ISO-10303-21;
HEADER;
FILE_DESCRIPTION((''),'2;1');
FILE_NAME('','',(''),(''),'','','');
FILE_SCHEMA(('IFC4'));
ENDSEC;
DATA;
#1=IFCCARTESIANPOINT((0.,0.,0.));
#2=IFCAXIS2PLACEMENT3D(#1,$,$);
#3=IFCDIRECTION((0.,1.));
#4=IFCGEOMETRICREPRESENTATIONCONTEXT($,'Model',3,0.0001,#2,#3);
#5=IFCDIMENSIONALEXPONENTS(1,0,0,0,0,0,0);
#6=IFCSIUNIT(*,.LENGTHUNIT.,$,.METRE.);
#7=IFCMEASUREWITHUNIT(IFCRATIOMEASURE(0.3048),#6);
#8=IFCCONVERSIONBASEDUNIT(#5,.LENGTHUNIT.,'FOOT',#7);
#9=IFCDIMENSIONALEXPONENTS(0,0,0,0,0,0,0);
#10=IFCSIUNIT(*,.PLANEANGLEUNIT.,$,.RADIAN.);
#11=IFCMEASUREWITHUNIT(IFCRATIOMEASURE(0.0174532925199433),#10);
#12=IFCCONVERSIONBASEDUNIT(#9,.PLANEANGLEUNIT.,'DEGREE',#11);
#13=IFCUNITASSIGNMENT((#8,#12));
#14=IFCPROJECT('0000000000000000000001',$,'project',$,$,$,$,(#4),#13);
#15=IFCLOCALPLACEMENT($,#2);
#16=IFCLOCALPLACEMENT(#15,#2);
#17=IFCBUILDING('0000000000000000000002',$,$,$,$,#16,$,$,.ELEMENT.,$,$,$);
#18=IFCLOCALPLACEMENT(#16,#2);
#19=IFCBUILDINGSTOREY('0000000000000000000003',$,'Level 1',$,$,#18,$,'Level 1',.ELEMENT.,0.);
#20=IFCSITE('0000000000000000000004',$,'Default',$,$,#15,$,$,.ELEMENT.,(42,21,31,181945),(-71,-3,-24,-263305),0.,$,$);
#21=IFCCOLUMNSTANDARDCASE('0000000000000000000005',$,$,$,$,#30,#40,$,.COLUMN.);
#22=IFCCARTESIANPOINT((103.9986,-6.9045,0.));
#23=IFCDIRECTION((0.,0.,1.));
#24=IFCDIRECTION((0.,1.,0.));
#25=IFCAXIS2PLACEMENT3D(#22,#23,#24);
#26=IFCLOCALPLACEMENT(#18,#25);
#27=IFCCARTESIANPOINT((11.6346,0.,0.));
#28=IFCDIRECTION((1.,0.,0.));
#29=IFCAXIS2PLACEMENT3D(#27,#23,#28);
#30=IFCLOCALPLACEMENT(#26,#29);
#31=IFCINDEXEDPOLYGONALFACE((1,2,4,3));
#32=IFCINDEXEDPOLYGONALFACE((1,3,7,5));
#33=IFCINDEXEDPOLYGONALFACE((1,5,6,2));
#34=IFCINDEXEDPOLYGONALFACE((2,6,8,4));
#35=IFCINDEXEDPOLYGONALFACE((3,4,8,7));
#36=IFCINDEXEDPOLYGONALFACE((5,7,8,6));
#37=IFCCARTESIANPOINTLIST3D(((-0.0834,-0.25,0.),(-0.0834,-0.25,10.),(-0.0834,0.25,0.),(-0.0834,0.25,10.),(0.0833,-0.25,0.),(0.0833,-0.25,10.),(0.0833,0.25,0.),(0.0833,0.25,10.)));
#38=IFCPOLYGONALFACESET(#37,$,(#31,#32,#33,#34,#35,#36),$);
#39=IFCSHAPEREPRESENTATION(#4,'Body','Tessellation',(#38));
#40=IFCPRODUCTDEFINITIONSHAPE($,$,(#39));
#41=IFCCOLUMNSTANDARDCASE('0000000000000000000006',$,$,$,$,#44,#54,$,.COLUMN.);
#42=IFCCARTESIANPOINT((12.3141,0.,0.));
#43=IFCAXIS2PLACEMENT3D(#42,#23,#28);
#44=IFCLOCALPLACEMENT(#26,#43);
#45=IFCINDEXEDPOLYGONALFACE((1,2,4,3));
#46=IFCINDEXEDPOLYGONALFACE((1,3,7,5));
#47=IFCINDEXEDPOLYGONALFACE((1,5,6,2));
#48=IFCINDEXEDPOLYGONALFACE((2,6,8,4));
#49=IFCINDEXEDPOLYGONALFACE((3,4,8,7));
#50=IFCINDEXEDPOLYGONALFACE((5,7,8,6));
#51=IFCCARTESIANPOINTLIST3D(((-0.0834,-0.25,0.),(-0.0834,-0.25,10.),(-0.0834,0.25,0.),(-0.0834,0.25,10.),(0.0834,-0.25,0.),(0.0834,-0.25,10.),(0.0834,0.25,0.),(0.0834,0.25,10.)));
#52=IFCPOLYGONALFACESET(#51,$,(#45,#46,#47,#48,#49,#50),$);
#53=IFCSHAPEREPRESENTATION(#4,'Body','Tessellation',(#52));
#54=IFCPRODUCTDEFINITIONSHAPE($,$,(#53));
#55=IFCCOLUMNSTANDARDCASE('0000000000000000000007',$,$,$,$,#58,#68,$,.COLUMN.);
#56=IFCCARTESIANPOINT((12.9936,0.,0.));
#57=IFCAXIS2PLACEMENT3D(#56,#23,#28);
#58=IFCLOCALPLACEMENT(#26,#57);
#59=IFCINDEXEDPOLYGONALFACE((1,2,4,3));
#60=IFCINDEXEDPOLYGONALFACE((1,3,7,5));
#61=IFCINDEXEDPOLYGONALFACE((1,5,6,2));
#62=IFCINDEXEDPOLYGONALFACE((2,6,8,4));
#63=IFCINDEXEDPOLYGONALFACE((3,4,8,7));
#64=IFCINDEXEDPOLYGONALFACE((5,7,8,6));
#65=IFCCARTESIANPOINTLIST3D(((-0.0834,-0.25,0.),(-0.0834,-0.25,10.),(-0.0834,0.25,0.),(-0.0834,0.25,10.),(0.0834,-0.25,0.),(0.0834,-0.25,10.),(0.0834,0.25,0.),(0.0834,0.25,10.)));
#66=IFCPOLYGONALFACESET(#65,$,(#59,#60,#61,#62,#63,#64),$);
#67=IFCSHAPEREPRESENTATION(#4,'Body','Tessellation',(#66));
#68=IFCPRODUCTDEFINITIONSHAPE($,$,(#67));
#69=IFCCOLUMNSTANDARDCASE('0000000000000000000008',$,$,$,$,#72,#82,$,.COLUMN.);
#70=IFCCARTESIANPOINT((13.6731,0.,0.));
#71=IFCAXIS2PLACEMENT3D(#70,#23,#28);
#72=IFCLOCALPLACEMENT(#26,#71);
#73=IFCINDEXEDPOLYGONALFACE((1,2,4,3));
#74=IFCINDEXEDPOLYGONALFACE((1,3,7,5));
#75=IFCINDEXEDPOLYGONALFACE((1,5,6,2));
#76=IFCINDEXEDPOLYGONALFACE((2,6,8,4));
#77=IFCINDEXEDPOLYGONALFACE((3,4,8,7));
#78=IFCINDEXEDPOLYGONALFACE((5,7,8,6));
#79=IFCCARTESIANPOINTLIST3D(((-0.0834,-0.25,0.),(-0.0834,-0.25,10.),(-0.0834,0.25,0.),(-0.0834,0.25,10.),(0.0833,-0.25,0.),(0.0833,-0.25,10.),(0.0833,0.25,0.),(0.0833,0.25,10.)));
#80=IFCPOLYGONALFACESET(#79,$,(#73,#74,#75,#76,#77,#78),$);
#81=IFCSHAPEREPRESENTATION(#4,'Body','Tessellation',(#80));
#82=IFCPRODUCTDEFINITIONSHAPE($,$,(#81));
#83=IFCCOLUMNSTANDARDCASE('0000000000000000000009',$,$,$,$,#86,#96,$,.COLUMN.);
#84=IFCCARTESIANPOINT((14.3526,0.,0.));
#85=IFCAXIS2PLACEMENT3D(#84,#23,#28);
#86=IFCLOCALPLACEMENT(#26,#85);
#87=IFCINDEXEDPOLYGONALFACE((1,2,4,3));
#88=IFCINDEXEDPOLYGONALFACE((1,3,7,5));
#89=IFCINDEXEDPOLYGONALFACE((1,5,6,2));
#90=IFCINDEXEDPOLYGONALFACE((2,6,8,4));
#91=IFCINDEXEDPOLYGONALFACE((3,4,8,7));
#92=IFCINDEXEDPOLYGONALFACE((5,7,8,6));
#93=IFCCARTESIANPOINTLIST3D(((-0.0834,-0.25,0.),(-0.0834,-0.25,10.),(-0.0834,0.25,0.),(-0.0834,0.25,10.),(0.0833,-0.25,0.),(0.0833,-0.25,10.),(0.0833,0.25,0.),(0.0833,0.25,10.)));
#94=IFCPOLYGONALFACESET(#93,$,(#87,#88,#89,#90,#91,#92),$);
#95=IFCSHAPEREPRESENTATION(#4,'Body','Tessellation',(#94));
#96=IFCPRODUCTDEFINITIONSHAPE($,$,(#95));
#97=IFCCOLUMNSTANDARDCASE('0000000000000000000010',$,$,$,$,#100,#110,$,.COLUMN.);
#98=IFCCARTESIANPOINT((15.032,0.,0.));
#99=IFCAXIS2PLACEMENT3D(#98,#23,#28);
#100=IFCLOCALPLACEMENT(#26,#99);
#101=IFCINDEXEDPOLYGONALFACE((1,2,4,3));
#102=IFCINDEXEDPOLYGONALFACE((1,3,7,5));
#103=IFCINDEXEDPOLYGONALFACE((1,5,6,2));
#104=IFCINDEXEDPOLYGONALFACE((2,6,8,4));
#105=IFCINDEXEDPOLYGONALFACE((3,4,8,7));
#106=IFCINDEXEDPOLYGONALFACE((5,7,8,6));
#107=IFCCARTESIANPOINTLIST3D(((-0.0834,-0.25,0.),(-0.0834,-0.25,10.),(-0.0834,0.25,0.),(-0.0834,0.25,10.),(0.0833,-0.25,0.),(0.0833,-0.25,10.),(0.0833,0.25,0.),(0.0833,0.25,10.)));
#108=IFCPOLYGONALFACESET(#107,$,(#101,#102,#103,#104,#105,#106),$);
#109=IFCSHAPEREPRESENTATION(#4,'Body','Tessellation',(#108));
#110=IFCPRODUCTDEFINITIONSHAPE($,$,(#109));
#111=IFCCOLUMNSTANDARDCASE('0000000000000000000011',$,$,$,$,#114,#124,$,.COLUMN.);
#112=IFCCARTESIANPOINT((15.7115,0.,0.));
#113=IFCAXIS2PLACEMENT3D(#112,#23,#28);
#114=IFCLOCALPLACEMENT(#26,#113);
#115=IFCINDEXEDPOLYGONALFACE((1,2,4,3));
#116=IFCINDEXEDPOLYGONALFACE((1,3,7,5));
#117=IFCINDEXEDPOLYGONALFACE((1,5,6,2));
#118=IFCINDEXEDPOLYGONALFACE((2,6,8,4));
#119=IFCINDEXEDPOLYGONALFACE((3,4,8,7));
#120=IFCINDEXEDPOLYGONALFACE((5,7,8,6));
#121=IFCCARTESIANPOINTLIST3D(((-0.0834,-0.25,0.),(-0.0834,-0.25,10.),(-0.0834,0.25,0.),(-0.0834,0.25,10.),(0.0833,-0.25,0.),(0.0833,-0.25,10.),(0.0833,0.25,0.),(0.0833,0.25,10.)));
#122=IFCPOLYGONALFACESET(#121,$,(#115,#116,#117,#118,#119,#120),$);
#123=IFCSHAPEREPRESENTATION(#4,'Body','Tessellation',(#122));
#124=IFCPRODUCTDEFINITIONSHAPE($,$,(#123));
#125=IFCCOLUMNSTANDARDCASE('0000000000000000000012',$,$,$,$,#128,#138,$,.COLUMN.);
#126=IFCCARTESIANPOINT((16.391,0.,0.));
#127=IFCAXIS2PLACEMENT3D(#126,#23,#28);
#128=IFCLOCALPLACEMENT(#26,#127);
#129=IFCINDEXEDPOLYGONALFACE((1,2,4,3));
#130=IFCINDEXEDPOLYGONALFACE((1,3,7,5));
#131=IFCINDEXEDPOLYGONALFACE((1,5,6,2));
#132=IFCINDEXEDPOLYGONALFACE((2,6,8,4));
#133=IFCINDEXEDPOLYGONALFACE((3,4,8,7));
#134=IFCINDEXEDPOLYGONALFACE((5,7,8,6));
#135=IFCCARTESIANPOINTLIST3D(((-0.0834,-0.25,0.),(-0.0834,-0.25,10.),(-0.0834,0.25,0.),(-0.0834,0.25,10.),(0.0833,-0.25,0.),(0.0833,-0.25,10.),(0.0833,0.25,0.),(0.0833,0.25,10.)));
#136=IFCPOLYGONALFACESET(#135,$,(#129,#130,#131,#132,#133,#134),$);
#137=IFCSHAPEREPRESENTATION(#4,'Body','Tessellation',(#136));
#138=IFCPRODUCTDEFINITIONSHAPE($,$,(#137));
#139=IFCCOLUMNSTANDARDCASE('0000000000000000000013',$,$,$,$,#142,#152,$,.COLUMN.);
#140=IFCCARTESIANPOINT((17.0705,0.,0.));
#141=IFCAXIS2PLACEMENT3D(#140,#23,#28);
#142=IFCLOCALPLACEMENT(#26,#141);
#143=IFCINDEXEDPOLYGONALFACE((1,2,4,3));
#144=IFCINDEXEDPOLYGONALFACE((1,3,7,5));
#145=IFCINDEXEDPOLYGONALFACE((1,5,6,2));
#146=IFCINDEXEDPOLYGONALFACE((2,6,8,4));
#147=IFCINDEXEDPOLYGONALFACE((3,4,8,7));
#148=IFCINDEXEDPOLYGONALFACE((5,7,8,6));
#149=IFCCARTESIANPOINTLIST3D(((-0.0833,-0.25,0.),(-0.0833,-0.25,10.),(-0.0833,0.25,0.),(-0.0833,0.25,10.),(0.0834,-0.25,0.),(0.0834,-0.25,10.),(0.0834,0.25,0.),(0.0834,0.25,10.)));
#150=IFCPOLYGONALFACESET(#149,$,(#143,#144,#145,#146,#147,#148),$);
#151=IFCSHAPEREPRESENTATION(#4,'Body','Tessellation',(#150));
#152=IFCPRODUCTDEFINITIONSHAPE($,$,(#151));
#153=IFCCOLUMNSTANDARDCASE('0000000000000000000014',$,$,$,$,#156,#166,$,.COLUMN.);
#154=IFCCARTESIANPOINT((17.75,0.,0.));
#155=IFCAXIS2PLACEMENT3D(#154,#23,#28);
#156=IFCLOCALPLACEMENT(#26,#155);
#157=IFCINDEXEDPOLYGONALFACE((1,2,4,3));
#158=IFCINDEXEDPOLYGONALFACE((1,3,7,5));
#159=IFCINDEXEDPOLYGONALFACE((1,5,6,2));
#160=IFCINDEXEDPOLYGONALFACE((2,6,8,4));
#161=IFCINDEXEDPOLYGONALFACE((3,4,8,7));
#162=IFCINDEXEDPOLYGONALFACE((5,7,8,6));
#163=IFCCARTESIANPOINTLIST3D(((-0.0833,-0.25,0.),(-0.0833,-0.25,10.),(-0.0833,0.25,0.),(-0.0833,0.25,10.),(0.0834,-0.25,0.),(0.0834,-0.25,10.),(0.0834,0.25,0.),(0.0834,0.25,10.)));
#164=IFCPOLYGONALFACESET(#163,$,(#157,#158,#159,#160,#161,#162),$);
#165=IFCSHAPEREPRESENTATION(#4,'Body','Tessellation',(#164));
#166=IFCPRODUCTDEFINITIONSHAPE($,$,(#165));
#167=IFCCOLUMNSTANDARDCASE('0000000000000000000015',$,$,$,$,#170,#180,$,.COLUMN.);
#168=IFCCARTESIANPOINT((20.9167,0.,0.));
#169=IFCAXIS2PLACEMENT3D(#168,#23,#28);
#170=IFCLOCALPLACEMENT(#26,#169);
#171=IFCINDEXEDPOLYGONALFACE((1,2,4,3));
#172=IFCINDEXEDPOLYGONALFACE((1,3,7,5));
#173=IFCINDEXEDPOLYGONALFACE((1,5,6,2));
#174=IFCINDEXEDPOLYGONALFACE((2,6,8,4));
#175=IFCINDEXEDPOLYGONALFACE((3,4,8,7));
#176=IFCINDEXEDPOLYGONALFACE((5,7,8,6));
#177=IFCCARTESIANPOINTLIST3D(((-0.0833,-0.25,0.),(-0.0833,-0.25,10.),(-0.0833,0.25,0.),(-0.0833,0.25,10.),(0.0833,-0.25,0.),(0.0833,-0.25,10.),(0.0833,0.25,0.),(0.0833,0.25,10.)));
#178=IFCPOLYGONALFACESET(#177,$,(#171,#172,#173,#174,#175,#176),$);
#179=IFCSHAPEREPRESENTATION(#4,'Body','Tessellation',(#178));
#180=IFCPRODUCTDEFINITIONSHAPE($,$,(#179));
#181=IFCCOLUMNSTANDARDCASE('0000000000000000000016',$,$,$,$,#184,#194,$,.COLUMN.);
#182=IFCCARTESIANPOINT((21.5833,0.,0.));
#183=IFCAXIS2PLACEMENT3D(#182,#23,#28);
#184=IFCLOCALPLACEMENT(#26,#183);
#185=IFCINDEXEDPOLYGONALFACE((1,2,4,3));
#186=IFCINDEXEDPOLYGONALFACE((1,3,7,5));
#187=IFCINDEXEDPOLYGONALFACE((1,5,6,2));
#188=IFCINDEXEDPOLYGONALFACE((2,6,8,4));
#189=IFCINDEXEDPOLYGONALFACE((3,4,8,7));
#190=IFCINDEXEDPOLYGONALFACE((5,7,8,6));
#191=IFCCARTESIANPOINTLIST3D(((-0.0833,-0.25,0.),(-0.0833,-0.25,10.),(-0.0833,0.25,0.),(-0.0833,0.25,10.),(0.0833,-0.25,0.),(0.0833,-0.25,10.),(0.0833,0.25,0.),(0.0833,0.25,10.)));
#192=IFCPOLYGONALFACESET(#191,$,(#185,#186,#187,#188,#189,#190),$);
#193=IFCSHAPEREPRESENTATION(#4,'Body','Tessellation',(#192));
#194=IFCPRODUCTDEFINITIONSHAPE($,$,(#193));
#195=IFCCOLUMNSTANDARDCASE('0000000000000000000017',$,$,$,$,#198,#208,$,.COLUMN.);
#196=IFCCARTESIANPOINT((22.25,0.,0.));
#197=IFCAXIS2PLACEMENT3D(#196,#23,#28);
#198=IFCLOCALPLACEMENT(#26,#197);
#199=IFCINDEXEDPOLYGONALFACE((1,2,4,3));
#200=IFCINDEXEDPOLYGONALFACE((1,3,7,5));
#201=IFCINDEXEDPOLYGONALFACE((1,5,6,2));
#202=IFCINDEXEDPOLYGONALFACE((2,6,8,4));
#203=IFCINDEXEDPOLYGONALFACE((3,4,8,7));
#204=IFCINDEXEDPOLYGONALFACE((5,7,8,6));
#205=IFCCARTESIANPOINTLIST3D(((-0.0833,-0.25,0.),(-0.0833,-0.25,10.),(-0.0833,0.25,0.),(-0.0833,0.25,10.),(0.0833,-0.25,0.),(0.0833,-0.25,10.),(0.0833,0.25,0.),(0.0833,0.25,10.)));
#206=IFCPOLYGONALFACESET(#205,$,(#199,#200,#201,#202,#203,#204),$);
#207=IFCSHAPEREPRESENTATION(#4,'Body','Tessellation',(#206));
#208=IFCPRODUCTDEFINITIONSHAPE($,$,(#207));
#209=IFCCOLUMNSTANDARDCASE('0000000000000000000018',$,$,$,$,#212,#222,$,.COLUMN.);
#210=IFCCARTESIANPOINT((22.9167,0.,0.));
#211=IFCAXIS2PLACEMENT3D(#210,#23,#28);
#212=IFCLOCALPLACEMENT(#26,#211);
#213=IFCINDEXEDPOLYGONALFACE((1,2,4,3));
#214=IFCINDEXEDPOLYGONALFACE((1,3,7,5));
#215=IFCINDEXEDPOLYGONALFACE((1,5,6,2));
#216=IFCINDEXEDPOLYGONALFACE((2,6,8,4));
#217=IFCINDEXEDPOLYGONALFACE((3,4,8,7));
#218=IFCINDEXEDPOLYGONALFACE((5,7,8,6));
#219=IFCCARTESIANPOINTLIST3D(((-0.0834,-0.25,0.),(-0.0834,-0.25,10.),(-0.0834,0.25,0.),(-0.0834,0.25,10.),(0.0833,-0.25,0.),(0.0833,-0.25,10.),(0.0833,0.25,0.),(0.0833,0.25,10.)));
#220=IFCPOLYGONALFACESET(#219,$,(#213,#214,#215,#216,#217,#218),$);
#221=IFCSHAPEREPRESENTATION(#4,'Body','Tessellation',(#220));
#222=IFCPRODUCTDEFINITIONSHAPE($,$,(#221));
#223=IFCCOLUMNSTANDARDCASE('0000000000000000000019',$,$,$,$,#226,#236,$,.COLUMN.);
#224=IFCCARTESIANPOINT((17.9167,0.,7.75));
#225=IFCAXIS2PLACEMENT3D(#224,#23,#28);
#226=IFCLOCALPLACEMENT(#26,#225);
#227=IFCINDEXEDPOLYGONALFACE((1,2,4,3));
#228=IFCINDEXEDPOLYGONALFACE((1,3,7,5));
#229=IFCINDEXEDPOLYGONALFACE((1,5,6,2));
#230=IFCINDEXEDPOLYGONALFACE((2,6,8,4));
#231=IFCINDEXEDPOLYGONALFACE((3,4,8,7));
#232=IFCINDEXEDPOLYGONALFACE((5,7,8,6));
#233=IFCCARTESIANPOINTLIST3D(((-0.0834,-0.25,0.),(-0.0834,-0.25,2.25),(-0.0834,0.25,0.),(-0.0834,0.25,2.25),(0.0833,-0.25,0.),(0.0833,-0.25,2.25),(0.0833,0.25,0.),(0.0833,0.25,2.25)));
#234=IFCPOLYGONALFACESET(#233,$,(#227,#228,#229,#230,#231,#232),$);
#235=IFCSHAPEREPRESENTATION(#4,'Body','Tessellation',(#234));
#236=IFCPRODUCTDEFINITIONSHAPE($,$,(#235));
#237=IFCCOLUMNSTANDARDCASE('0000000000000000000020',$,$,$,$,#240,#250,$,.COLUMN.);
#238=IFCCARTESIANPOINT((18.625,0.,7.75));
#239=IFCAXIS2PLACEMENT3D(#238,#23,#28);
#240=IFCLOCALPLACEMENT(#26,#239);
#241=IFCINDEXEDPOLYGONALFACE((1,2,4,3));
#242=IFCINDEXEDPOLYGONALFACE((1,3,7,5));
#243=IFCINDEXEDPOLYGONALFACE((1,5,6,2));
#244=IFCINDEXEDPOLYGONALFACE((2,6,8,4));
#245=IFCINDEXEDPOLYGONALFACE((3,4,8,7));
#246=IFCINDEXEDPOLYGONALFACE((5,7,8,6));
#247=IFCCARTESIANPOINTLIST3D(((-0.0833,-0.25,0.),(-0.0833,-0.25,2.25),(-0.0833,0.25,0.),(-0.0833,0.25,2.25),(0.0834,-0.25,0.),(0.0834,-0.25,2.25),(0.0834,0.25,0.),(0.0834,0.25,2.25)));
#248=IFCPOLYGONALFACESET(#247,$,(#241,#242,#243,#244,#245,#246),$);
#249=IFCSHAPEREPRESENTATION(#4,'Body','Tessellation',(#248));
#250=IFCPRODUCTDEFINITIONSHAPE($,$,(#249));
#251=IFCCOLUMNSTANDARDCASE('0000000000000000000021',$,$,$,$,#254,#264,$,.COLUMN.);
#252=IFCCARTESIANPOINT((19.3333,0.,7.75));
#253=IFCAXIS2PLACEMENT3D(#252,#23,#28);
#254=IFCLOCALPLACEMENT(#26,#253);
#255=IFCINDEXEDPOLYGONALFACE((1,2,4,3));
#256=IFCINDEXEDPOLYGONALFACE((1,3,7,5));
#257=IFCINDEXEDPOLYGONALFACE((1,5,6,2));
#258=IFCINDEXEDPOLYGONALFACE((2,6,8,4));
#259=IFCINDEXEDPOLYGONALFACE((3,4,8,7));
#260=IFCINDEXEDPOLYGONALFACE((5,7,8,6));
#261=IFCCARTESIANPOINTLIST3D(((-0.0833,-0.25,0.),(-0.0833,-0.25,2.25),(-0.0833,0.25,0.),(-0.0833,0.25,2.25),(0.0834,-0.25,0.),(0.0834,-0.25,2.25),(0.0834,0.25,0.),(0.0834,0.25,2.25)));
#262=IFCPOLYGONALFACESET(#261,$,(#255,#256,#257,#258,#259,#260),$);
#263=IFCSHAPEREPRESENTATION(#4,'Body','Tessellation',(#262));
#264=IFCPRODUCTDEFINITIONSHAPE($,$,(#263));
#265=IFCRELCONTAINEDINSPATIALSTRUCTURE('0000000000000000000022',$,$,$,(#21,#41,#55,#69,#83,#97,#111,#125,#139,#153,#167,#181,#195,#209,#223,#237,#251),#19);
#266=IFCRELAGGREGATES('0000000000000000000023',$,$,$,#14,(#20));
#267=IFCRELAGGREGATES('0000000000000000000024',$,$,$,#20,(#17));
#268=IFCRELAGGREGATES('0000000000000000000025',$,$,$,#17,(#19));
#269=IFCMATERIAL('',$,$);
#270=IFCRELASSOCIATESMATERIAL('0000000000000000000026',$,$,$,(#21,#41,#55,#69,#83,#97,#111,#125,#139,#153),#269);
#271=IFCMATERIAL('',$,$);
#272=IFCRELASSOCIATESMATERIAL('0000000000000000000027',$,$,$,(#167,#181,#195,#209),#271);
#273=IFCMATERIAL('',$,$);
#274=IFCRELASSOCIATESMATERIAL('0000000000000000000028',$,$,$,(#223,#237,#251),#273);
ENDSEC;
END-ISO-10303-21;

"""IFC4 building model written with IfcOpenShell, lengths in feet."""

from ifc_helpers import new_model, entity, si_unit, converted_unit, direction, frame, origin, place, context, project, spatial, rectangle, extrude, material, element, save


model = new_model("IFC4")

# Units and contexts
model_context = context("Model", 3, precision=0.0001, world=origin(), true_north=direction((0.0, 1.0)))
ifc_project = project(units=[converted_unit("LENGTHUNIT", "FOOT", entity("IfcRatioMeasure", 0.3048), si_unit("LENGTHUNIT", "METRE"), dimensions=[1, 0, 0, 0, 0, 0, 0]), converted_unit("PLANEANGLEUNIT", "DEGREE", entity("IfcRatioMeasure", 0.0174532925199433), si_unit("PLANEANGLEUNIT", "RADIAN"), dimensions=[0, 0, 0, 0, 0, 0, 0])], contexts=[model_context])

# Site, building, storey
site_placement = place(None, origin())
site = spatial("IfcSite", under=ifc_project, at=site_placement, Name="Default", CompositionType="ELEMENT", RefLatitude=(42, 21, 31, 181945), RefLongitude=(-71, -3, -24, -263305), RefElevation=0.0)
building_placement = place(site_placement, origin())
building = spatial("IfcBuilding", under=site, at=building_placement, CompositionType="ELEMENT")
storey_placement = place(building_placement, origin())
storey = spatial("IfcBuildingStorey", under=building, at=storey_placement, Name="Level 1", LongName="Level 1", CompositionType="ELEMENT", Elevation=0.0)

# Columns
ifc_material_1 = material(Name="")
placement = place(storey_placement, frame((103.9986, -6.9045, 0.0), z_axis=(0.0, 0.0, 1.0), x_axis=(0.0, 1.0, 0.0)))
for number, where, z_axis, x_axis in (
    (1, (11.6346, 0.0, 0.0), (0.0, 0.0, 1.0), (1.0, 0.0, 0.0)),
    (2, (12.3141, 0.0, 0.0), (0.0, 0.0, 1.0), (1.0, 0.0, 0.0)),
    (3, (12.9936, 0.0, 0.0), (0.0, 0.0, 1.0), (1.0, 0.0, 0.0)),
    (4, (13.6731, 0.0, 0.0), (0.0, 0.0, 1.0), (1.0, 0.0, 0.0)),
    (5, (14.3526, 0.0, 0.0), (0.0, 0.0, 1.0), (1.0, 0.0, 0.0)),
    (6, (15.032, 0.0, 0.0), (0.0, 0.0, 1.0), (1.0, 0.0, 0.0)),
    (7, (15.7115, 0.0, 0.0), (0.0, 0.0, 1.0), (1.0, 0.0, 0.0)),
    (8, (16.391, 0.0, 0.0), (0.0, 0.0, 1.0), (1.0, 0.0, 0.0)),
    (9, (17.0705, 0.0, 0.0), (0.0, 0.0, 1.0), (1.0, 0.0, 0.0)),
    (10, (17.75, 0.0, 0.0), (0.0, 0.0, 1.0), (1.0, 0.0, 0.0)),
):
    element("IfcColumnStandardCase", number, at=place(placement, frame(where, z_axis=z_axis, x_axis=x_axis)), inside=storey, material=ifc_material_1, PredefinedType="COLUMN", context=model_context, shape_type="SweptSolid", body=[
        extrude(rectangle(XDim=0.1667, YDim=0.5), origin(), (0.0, 0.0, 1.0), 10.0),
    ])
ifc_material_2 = material(Name="")
for number, where, z_axis, x_axis in (
    (11, (20.9167, 0.0, 0.0), (0.0, 0.0, 1.0), (1.0, 0.0, 0.0)),
    (12, (21.5833, 0.0, 0.0), (0.0, 0.0, 1.0), (1.0, 0.0, 0.0)),
    (13, (22.25, 0.0, 0.0), (0.0, 0.0, 1.0), (1.0, 0.0, 0.0)),
    (14, (22.9167, 0.0, 0.0), (0.0, 0.0, 1.0), (1.0, 0.0, 0.0)),
):
    element("IfcColumnStandardCase", number, at=place(placement, frame(where, z_axis=z_axis, x_axis=x_axis)), inside=storey, material=ifc_material_2, PredefinedType="COLUMN", context=model_context, shape_type="SweptSolid", body=[
        extrude(rectangle(XDim=0.1667, YDim=0.5), origin(), (0.0, 0.0, 1.0), 10.0),
    ])
ifc_material_3 = material(Name="")
for number, where, z_axis, x_axis in (
    (15, (17.9167, 0.0, 7.75), (0.0, 0.0, 1.0), (1.0, 0.0, 0.0)),
    (16, (18.625, 0.0, 7.75), (0.0, 0.0, 1.0), (1.0, 0.0, 0.0)),
    (17, (19.3333, 0.0, 7.75), (0.0, 0.0, 1.0), (1.0, 0.0, 0.0)),
):
    element("IfcColumnStandardCase", number, at=place(placement, frame(where, z_axis=z_axis, x_axis=x_axis)), inside=storey, material=ifc_material_3, PredefinedType="COLUMN", context=model_context, shape_type="SweptSolid", body=[
        extrude(rectangle(XDim=0.1667, YDim=0.5), origin(), (0.0, 0.0, 1.0), 2.25),
    ])

save(model, "model.ifc")
